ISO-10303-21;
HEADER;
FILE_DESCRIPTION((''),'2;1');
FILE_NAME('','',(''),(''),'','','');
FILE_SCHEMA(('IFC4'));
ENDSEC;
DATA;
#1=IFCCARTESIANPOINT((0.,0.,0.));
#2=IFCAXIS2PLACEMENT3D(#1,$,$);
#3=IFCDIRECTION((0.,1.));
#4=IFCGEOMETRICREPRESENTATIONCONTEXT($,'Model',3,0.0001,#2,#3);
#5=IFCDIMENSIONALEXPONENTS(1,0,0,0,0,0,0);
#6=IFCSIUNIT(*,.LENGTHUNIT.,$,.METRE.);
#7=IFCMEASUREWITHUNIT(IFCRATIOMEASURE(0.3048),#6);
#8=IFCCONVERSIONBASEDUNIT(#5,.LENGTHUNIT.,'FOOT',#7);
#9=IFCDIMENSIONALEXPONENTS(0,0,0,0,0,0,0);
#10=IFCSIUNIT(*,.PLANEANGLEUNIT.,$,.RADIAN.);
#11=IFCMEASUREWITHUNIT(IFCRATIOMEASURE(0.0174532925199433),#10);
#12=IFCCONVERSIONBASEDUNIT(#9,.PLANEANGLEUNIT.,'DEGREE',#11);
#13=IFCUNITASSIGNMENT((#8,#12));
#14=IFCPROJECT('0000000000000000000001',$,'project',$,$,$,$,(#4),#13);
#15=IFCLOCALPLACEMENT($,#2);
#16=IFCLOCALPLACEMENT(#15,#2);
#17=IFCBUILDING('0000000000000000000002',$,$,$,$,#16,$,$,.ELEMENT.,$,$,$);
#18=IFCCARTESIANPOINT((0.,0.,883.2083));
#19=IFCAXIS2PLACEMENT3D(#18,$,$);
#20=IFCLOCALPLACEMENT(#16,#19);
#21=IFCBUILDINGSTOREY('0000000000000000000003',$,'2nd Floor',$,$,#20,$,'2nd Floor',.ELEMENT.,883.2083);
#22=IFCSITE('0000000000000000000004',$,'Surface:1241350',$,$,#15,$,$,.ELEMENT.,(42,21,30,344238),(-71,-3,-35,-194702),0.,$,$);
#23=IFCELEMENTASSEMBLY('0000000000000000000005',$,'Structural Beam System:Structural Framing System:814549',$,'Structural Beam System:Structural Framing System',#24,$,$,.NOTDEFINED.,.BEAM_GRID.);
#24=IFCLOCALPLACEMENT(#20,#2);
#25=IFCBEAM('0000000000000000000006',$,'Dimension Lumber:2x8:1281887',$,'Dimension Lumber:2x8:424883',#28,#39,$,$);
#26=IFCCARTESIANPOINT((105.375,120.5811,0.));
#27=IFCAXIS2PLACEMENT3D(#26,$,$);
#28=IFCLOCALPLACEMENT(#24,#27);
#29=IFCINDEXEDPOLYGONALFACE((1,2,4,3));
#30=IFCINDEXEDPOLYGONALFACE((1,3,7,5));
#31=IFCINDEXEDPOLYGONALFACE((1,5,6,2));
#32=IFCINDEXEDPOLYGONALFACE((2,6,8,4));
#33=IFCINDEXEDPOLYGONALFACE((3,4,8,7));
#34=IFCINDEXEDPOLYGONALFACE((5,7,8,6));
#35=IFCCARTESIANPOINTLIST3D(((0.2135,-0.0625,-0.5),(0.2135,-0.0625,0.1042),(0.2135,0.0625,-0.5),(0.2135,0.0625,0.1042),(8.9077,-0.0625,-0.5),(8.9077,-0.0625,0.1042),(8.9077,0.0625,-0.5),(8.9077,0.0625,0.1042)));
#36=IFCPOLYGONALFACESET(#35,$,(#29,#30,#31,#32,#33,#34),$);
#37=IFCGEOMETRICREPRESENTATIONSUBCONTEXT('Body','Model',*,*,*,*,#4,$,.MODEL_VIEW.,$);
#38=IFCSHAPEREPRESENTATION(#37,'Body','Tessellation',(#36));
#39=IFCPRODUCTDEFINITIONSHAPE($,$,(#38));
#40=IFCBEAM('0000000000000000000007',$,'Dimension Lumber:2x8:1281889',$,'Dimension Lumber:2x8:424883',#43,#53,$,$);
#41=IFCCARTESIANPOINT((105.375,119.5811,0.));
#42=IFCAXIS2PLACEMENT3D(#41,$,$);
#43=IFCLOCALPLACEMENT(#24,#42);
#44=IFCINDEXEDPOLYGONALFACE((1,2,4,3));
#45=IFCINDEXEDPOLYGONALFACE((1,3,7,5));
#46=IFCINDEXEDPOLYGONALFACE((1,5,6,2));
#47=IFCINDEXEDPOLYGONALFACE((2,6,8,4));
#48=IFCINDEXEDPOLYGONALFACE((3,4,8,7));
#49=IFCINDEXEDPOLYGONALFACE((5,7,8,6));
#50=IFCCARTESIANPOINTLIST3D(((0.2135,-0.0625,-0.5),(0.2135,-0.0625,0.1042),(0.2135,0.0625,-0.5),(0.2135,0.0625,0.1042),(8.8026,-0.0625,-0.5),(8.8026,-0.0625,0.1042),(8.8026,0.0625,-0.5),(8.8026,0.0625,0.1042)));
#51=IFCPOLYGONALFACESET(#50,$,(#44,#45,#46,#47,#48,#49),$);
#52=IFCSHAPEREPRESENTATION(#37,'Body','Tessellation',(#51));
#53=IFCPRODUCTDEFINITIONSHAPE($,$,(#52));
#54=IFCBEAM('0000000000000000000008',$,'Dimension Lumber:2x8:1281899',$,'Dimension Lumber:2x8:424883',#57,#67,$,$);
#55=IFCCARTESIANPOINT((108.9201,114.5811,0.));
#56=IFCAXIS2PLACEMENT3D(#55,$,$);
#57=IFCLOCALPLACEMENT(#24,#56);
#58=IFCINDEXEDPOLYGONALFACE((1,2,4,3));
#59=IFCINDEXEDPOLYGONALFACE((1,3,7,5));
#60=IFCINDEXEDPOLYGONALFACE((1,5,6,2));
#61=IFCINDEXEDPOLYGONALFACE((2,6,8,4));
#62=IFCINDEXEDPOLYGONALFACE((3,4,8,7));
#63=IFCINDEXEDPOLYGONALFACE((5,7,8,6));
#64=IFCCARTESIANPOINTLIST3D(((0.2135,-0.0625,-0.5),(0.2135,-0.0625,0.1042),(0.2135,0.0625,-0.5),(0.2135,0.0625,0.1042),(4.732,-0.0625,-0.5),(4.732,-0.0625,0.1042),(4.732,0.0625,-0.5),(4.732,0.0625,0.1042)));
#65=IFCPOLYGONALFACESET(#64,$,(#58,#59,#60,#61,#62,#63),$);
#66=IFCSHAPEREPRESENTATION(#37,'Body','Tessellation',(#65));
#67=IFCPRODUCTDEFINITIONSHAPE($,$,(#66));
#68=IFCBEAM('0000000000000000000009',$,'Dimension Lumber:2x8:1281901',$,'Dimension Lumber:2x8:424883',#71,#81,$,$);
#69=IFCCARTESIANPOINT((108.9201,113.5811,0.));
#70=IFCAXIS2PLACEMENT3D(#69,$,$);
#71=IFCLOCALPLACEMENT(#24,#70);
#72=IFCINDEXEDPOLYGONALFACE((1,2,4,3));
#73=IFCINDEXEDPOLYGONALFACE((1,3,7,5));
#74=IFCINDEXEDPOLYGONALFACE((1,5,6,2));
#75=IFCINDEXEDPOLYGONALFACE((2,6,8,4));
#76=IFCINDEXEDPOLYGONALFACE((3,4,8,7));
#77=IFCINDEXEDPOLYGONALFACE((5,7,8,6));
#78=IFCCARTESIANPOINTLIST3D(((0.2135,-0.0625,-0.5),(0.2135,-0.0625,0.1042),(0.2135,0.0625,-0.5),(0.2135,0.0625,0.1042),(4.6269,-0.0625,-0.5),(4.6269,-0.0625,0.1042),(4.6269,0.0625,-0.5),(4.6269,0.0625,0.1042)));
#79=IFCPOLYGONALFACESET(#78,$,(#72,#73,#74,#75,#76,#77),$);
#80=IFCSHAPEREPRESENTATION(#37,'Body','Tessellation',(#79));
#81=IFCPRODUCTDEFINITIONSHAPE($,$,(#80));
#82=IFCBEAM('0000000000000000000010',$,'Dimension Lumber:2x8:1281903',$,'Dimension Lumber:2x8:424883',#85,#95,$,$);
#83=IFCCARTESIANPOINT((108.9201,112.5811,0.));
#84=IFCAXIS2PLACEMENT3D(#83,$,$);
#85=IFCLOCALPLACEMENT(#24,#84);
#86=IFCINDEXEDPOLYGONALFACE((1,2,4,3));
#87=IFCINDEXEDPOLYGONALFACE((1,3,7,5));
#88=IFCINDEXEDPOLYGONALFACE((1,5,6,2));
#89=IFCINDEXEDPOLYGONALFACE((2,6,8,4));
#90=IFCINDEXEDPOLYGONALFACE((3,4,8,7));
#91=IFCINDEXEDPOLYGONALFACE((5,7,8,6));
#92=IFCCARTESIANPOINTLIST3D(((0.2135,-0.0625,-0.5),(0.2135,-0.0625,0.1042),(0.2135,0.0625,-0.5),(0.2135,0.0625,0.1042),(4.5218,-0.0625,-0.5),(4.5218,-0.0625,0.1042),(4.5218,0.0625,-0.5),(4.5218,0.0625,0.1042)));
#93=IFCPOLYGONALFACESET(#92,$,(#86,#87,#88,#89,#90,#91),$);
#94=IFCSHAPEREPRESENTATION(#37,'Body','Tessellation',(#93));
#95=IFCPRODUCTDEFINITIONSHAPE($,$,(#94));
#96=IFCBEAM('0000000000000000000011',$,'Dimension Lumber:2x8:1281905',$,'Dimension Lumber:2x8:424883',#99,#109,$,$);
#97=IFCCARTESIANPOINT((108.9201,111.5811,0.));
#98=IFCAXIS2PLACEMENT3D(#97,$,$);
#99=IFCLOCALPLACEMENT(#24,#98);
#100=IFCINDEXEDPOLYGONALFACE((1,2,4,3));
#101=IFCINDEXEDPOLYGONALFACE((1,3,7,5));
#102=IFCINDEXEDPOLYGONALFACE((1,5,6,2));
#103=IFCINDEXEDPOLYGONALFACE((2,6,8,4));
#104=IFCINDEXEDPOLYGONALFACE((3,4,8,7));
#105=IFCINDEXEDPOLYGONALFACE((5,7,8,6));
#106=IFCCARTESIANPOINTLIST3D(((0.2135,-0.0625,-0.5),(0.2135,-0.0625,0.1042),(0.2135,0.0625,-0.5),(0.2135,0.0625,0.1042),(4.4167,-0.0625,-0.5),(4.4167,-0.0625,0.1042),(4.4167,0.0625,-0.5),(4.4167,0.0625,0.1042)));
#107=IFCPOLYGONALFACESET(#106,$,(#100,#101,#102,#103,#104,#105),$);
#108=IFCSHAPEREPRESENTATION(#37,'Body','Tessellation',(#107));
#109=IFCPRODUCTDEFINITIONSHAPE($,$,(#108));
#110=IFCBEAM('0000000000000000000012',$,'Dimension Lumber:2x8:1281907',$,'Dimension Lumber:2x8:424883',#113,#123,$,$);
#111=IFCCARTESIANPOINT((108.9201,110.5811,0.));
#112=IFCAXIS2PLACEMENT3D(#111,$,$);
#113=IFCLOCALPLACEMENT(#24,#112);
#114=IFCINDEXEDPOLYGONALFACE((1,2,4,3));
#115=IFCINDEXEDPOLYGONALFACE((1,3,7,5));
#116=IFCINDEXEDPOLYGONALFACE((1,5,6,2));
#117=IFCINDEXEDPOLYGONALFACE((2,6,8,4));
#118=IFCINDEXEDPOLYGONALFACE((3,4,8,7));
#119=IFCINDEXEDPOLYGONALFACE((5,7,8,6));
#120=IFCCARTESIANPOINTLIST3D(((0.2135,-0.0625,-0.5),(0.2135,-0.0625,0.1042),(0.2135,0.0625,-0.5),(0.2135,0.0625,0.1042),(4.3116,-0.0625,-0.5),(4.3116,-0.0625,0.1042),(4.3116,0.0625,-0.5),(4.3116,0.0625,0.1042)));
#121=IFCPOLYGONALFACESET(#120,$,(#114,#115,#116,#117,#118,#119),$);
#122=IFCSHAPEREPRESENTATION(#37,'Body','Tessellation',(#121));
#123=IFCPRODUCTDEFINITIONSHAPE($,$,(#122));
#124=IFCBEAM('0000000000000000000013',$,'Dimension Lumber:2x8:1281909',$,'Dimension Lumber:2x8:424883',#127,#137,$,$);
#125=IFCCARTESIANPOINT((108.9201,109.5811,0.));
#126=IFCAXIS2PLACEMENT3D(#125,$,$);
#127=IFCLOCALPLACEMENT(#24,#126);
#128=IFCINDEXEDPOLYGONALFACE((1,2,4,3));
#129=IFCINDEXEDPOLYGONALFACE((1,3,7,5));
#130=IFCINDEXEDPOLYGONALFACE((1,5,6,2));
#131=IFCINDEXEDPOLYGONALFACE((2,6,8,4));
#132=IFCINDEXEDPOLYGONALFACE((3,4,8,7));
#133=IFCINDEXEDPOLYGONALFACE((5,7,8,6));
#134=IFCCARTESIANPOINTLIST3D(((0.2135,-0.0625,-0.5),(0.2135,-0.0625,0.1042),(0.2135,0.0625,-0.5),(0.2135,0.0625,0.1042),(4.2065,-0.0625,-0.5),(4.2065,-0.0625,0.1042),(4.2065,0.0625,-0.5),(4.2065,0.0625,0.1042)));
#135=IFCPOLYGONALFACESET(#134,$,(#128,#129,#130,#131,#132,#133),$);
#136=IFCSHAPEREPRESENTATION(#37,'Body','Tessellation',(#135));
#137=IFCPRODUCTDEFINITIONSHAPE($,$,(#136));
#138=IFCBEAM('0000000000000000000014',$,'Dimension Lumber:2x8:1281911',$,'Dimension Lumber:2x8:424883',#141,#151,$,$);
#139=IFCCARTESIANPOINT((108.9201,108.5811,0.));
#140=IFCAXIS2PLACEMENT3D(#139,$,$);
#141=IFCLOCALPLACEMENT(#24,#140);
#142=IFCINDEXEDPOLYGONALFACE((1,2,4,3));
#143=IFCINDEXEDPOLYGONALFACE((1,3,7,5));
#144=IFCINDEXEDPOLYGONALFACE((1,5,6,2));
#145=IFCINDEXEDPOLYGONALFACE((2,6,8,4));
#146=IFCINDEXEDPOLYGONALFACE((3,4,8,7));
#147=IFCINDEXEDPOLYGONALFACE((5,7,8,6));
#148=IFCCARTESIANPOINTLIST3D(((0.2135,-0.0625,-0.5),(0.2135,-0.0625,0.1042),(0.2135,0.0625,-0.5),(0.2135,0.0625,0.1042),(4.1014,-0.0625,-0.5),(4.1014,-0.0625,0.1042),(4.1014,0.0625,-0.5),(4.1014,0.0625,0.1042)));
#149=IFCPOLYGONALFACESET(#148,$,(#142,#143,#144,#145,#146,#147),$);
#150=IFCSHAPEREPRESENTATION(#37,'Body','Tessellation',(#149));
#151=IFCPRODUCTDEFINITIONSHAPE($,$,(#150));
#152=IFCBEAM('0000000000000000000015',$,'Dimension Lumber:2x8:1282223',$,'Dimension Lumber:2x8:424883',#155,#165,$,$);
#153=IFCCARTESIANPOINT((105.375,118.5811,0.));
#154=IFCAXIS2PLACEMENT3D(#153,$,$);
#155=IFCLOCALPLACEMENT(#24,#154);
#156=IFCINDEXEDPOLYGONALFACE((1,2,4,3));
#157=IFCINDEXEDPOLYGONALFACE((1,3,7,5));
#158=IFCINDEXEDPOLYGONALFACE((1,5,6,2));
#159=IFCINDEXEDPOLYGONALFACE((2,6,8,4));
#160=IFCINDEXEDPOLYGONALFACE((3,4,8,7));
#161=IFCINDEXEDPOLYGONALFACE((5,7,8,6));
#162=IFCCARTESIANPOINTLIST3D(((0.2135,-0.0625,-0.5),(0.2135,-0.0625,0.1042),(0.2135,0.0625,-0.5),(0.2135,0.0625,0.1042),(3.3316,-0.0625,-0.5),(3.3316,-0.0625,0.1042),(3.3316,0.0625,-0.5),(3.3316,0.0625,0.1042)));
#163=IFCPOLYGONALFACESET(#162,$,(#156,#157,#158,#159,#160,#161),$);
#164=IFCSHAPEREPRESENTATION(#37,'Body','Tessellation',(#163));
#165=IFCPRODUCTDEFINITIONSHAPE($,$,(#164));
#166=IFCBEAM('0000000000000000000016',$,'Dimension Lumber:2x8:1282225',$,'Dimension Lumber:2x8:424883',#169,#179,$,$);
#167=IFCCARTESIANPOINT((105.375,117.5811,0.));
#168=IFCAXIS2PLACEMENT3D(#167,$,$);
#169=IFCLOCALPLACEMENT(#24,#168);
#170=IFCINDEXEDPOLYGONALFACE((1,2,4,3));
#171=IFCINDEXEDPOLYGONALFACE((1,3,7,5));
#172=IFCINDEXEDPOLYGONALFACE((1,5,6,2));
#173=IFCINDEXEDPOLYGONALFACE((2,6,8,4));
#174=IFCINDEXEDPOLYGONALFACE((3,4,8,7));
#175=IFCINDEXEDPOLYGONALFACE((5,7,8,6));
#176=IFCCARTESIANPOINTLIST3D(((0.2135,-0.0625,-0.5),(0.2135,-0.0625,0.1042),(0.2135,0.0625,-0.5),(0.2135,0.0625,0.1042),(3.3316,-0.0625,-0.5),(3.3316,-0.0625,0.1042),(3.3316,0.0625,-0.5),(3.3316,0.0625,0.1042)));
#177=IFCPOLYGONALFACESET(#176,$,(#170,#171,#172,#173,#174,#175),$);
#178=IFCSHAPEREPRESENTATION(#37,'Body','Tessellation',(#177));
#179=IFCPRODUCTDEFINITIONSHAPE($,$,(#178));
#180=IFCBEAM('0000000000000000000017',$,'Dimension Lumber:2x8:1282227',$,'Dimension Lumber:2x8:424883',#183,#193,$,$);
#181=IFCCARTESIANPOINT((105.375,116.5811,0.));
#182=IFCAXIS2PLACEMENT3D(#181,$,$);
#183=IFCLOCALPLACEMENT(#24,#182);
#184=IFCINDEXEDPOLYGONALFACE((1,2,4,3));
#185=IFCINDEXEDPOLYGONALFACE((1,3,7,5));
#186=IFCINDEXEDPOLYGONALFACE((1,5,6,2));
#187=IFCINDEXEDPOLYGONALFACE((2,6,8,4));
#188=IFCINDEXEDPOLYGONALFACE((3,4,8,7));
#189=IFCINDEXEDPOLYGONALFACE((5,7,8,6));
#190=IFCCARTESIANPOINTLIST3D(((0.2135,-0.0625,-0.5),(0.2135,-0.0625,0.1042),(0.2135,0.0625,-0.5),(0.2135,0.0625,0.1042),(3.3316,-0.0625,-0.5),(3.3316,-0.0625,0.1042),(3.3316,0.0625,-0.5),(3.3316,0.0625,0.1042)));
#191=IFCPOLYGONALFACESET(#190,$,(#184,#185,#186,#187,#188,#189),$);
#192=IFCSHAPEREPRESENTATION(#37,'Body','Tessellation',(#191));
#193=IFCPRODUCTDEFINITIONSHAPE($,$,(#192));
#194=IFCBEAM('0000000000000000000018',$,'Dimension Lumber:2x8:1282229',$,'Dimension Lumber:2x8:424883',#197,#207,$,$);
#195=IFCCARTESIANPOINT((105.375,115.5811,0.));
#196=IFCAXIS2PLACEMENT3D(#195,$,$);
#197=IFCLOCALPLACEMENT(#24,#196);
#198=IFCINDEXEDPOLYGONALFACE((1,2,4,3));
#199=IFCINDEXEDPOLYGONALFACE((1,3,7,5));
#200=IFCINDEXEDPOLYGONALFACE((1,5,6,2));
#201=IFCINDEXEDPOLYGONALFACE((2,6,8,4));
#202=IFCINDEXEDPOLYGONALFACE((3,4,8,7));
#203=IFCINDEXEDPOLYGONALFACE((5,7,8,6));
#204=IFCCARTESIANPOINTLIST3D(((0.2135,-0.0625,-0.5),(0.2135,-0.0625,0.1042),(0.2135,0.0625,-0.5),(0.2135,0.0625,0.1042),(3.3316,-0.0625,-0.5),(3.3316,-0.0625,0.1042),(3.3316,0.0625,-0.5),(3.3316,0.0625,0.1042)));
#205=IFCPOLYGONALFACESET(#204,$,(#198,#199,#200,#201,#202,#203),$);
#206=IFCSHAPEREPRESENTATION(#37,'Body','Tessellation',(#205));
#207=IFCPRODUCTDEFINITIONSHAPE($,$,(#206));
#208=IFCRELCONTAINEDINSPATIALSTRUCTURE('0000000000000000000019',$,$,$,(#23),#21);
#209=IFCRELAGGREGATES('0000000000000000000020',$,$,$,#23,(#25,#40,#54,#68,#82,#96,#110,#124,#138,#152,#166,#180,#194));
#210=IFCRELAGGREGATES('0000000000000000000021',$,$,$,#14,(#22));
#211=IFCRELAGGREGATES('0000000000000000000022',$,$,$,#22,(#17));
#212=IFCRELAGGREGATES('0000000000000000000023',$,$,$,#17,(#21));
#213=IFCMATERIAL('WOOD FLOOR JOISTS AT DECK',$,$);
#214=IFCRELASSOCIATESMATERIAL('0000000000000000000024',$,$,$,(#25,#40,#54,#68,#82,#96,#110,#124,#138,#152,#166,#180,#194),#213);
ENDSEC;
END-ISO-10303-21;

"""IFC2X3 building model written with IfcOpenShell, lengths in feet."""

from ifc_helpers import new_model, entity, si_unit, converted_unit, direction, frame, frame_2d, origin, origin_2d_with_axis, place, context, subcontext, project, spatial, rectangle, extrude, material, element, aggregate, save


model = new_model("IFC2X3")

# Units and contexts
model_context = context("Model", 3, precision=0.0001, world=origin(), true_north=direction((0.0, 1.0)))
body_context = subcontext(model_context, "Body", "Model", "MODEL_VIEW")
ifc_project = project(units=[converted_unit("LENGTHUNIT", "FOOT", entity("IfcRatioMeasure", 0.3048), si_unit("LENGTHUNIT", "METRE"), dimensions=[1, 0, 0, 0, 0, 0, 0]), converted_unit("PLANEANGLEUNIT", "DEGREE", entity("IfcRatioMeasure", 0.0174532925199433), si_unit("PLANEANGLEUNIT", "RADIAN"), dimensions=[0, 0, 0, 0, 0, 0, 0])], contexts=[model_context])

# Site, building, storey
site_placement = place(None, origin())
site = spatial("IfcSite", under=ifc_project, at=site_placement, Name="Surface:1241350", CompositionType="ELEMENT", RefLatitude=(42, 21, 30, 344238), RefLongitude=(-71, -3, -35, -194702), RefElevation=0.0)
building_placement = place(site_placement, origin())
building = spatial("IfcBuilding", under=site, at=building_placement, CompositionType="ELEMENT")
storey_placement = place(building_placement, frame((0.0, 0.0, 883.2083)))
storey = spatial("IfcBuildingStorey", under=building, at=storey_placement, Name="2nd Floor", LongName="2nd Floor", CompositionType="ELEMENT", Elevation=883.2083)

# Element assembly, beams
assembly_placement = place(storey_placement, origin())
assembly = element("IfcElementAssembly", 1, at=assembly_placement, inside=storey, Name="Structural Beam System:Structural Framing System:814549", ObjectType="Structural Beam System:Structural Framing System", AssemblyPlace="NOTDEFINED", PredefinedType="BEAM_GRID")
ifc_material_1 = material(Name="WOOD FLOOR JOISTS AT DECK")
beam_1_placement = place(assembly_placement, frame((105.375, 120.5811, 0.0)))
beam_1 = element("IfcBeam", 2, at=beam_1_placement, material=ifc_material_1, Name="Dimension Lumber:2x8:1281887", ObjectType="Dimension Lumber:2x8:424883", context=body_context, shape_type="SweptSolid", body=[
    extrude(rectangle(XDim=0.6042, YDim=0.125, at=origin_2d_with_axis()), frame((0.2135, 0.0, -0.1979), z_axis=(1.0, 0.0, 0.0), x_axis=(0.0, 0.0, -1.0)), (0.0, 0.0, 1.0), 8.6942),
])
beam_2_placement = place(assembly_placement, frame((105.375, 119.5811, 0.0)))
beam_2 = element("IfcBeam", 3, at=beam_2_placement, material=ifc_material_1, Name="Dimension Lumber:2x8:1281889", ObjectType="Dimension Lumber:2x8:424883", context=body_context, shape_type="SweptSolid", body=[
    extrude(rectangle(XDim=0.6042, YDim=0.125, at=origin_2d_with_axis()), frame((0.2135, 0.0, -0.1979), z_axis=(1.0, 0.0, 0.0), x_axis=(0.0, 0.0, -1.0)), (0.0, 0.0, 1.0), 8.5891),
])
beam_3_placement = place(assembly_placement, frame((108.9201, 114.5811, 0.0)))
beam_3 = element("IfcBeam", 4, at=beam_3_placement, material=ifc_material_1, Name="Dimension Lumber:2x8:1281899", ObjectType="Dimension Lumber:2x8:424883", context=body_context, shape_type="SweptSolid", body=[
    extrude(rectangle(XDim=0.6042, YDim=0.125, at=origin_2d_with_axis()), frame((0.2135, 0.0, -0.1979), z_axis=(1.0, 0.0, 0.0), x_axis=(0.0, 0.0, -1.0)), (0.0, 0.0, 1.0), 4.5184),
])
beam_4_placement = place(assembly_placement, frame((108.9201, 113.5811, 0.0)))
beam_4 = element("IfcBeam", 5, at=beam_4_placement, material=ifc_material_1, Name="Dimension Lumber:2x8:1281901", ObjectType="Dimension Lumber:2x8:424883", context=body_context, shape_type="SweptSolid", body=[
    extrude(rectangle(XDim=0.6042, YDim=0.125, at=origin_2d_with_axis()), frame((0.2135, 0.0, -0.1979), z_axis=(1.0, 0.0, 0.0), x_axis=(0.0, 0.0, -1.0)), (0.0, 0.0, 1.0), 4.4133),
])
beam_5_placement = place(assembly_placement, frame((108.9201, 112.5811, 0.0)))
beam_5 = element("IfcBeam", 6, at=beam_5_placement, material=ifc_material_1, Name="Dimension Lumber:2x8:1281903", ObjectType="Dimension Lumber:2x8:424883", context=body_context, shape_type="SweptSolid", body=[
    extrude(rectangle(XDim=0.6042, YDim=0.125, at=origin_2d_with_axis()), frame((0.2135, 0.0, -0.1979), z_axis=(1.0, 0.0, 0.0), x_axis=(0.0, 0.0, -1.0)), (0.0, 0.0, 1.0), 4.3082),
])
beam_6_placement = place(assembly_placement, frame((108.9201, 111.5811, 0.0)))
beam_6 = element("IfcBeam", 7, at=beam_6_placement, material=ifc_material_1, Name="Dimension Lumber:2x8:1281905", ObjectType="Dimension Lumber:2x8:424883", context=body_context, shape_type="SweptSolid", body=[
    extrude(rectangle(XDim=0.6042, YDim=0.125, at=origin_2d_with_axis()), frame((0.2135, 0.0, -0.1979), z_axis=(1.0, 0.0, 0.0), x_axis=(0.0, 0.0, -1.0)), (0.0, 0.0, 1.0), 4.2031),
])
beam_7_placement = place(assembly_placement, frame((108.9201, 110.5811, 0.0)))
beam_7 = element("IfcBeam", 8, at=beam_7_placement, material=ifc_material_1, Name="Dimension Lumber:2x8:1281907", ObjectType="Dimension Lumber:2x8:424883", context=body_context, shape_type="SweptSolid", body=[
    extrude(rectangle(XDim=0.6042, YDim=0.125, at=origin_2d_with_axis()), frame((0.2135, 0.0, -0.1979), z_axis=(1.0, 0.0, 0.0), x_axis=(0.0, 0.0, -1.0)), (0.0, 0.0, 1.0), 4.098),
])
beam_8_placement = place(assembly_placement, frame((108.9201, 109.5811, 0.0)))
beam_8 = element("IfcBeam", 9, at=beam_8_placement, material=ifc_material_1, Name="Dimension Lumber:2x8:1281909", ObjectType="Dimension Lumber:2x8:424883", context=body_context, shape_type="SweptSolid", body=[
    extrude(rectangle(XDim=0.6042, YDim=0.125, at=origin_2d_with_axis()), frame((0.2135, 0.0, -0.1979), z_axis=(1.0, 0.0, 0.0), x_axis=(0.0, 0.0, -1.0)), (0.0, 0.0, 1.0), 3.9929),
])
beam_9_placement = place(assembly_placement, frame((108.9201, 108.5811, 0.0)))
beam_9 = element("IfcBeam", 10, at=beam_9_placement, material=ifc_material_1, Name="Dimension Lumber:2x8:1281911", ObjectType="Dimension Lumber:2x8:424883", context=body_context, shape_type="SweptSolid", body=[
    extrude(rectangle(XDim=0.6042, YDim=0.125, at=origin_2d_with_axis()), frame((0.2135, 0.0, -0.1979), z_axis=(1.0, 0.0, 0.0), x_axis=(0.0, 0.0, -1.0)), (0.0, 0.0, 1.0), 3.8878),
])
beam_10_placement = place(assembly_placement, frame((105.375, 118.5811, 0.0)))
beam_10 = element("IfcBeam", 11, at=beam_10_placement, material=ifc_material_1, Name="Dimension Lumber:2x8:1282223", ObjectType="Dimension Lumber:2x8:424883", context=body_context, shape_type="SweptSolid", body=[
    extrude(rectangle(XDim=0.6042, YDim=0.125, at=frame_2d((0.0, 0.0), x_axis=(1.0, 0.0))), frame((0.2135, 0.0, -0.1979), z_axis=(1.0, 0.0, 0.0), x_axis=(0.0, 0.0, -1.0)), (0.0, 0.0, 1.0), 3.118),
])
beam_11_placement = place(assembly_placement, frame((105.375, 117.5811, 0.0)))
beam_11 = element("IfcBeam", 12, at=beam_11_placement, material=ifc_material_1, Name="Dimension Lumber:2x8:1282225", ObjectType="Dimension Lumber:2x8:424883", context=body_context, shape_type="SweptSolid", body=[
    extrude(rectangle(XDim=0.6042, YDim=0.125, at=frame_2d((0.0, 0.0), x_axis=(1.0, 0.0))), frame((0.2135, 0.0, -0.1979), z_axis=(1.0, 0.0, 0.0), x_axis=(0.0, 0.0, -1.0)), (0.0, 0.0, 1.0), 3.118),
])
beam_12_placement = place(assembly_placement, frame((105.375, 116.5811, 0.0)))
beam_12 = element("IfcBeam", 13, at=beam_12_placement, material=ifc_material_1, Name="Dimension Lumber:2x8:1282227", ObjectType="Dimension Lumber:2x8:424883", context=body_context, shape_type="SweptSolid", body=[
    extrude(rectangle(XDim=0.6042, YDim=0.125, at=frame_2d((0.0, 0.0), x_axis=(1.0, 0.0))), frame((0.2135, 0.0, -0.1979), z_axis=(1.0, 0.0, 0.0), x_axis=(0.0, 0.0, -1.0)), (0.0, 0.0, 1.0), 3.118),
])
beam_13_placement = place(assembly_placement, frame((105.375, 115.5811, 0.0)))
beam_13 = element("IfcBeam", 14, at=beam_13_placement, material=ifc_material_1, Name="Dimension Lumber:2x8:1282229", ObjectType="Dimension Lumber:2x8:424883", context=body_context, shape_type="SweptSolid", body=[
    extrude(rectangle(XDim=0.6042, YDim=0.125, at=frame_2d((0.0, 0.0), x_axis=(1.0, 0.0))), frame((0.2135, 0.0, -0.1979), z_axis=(1.0, 0.0, 0.0), x_axis=(0.0, 0.0, -1.0)), (0.0, 0.0, 1.0), 3.118),
])
aggregate(assembly, [beam_1, beam_2, beam_3, beam_4, beam_5, beam_6, beam_7, beam_8, beam_9, beam_10, beam_11, beam_12, beam_13])

save(model, "model.ifc")
